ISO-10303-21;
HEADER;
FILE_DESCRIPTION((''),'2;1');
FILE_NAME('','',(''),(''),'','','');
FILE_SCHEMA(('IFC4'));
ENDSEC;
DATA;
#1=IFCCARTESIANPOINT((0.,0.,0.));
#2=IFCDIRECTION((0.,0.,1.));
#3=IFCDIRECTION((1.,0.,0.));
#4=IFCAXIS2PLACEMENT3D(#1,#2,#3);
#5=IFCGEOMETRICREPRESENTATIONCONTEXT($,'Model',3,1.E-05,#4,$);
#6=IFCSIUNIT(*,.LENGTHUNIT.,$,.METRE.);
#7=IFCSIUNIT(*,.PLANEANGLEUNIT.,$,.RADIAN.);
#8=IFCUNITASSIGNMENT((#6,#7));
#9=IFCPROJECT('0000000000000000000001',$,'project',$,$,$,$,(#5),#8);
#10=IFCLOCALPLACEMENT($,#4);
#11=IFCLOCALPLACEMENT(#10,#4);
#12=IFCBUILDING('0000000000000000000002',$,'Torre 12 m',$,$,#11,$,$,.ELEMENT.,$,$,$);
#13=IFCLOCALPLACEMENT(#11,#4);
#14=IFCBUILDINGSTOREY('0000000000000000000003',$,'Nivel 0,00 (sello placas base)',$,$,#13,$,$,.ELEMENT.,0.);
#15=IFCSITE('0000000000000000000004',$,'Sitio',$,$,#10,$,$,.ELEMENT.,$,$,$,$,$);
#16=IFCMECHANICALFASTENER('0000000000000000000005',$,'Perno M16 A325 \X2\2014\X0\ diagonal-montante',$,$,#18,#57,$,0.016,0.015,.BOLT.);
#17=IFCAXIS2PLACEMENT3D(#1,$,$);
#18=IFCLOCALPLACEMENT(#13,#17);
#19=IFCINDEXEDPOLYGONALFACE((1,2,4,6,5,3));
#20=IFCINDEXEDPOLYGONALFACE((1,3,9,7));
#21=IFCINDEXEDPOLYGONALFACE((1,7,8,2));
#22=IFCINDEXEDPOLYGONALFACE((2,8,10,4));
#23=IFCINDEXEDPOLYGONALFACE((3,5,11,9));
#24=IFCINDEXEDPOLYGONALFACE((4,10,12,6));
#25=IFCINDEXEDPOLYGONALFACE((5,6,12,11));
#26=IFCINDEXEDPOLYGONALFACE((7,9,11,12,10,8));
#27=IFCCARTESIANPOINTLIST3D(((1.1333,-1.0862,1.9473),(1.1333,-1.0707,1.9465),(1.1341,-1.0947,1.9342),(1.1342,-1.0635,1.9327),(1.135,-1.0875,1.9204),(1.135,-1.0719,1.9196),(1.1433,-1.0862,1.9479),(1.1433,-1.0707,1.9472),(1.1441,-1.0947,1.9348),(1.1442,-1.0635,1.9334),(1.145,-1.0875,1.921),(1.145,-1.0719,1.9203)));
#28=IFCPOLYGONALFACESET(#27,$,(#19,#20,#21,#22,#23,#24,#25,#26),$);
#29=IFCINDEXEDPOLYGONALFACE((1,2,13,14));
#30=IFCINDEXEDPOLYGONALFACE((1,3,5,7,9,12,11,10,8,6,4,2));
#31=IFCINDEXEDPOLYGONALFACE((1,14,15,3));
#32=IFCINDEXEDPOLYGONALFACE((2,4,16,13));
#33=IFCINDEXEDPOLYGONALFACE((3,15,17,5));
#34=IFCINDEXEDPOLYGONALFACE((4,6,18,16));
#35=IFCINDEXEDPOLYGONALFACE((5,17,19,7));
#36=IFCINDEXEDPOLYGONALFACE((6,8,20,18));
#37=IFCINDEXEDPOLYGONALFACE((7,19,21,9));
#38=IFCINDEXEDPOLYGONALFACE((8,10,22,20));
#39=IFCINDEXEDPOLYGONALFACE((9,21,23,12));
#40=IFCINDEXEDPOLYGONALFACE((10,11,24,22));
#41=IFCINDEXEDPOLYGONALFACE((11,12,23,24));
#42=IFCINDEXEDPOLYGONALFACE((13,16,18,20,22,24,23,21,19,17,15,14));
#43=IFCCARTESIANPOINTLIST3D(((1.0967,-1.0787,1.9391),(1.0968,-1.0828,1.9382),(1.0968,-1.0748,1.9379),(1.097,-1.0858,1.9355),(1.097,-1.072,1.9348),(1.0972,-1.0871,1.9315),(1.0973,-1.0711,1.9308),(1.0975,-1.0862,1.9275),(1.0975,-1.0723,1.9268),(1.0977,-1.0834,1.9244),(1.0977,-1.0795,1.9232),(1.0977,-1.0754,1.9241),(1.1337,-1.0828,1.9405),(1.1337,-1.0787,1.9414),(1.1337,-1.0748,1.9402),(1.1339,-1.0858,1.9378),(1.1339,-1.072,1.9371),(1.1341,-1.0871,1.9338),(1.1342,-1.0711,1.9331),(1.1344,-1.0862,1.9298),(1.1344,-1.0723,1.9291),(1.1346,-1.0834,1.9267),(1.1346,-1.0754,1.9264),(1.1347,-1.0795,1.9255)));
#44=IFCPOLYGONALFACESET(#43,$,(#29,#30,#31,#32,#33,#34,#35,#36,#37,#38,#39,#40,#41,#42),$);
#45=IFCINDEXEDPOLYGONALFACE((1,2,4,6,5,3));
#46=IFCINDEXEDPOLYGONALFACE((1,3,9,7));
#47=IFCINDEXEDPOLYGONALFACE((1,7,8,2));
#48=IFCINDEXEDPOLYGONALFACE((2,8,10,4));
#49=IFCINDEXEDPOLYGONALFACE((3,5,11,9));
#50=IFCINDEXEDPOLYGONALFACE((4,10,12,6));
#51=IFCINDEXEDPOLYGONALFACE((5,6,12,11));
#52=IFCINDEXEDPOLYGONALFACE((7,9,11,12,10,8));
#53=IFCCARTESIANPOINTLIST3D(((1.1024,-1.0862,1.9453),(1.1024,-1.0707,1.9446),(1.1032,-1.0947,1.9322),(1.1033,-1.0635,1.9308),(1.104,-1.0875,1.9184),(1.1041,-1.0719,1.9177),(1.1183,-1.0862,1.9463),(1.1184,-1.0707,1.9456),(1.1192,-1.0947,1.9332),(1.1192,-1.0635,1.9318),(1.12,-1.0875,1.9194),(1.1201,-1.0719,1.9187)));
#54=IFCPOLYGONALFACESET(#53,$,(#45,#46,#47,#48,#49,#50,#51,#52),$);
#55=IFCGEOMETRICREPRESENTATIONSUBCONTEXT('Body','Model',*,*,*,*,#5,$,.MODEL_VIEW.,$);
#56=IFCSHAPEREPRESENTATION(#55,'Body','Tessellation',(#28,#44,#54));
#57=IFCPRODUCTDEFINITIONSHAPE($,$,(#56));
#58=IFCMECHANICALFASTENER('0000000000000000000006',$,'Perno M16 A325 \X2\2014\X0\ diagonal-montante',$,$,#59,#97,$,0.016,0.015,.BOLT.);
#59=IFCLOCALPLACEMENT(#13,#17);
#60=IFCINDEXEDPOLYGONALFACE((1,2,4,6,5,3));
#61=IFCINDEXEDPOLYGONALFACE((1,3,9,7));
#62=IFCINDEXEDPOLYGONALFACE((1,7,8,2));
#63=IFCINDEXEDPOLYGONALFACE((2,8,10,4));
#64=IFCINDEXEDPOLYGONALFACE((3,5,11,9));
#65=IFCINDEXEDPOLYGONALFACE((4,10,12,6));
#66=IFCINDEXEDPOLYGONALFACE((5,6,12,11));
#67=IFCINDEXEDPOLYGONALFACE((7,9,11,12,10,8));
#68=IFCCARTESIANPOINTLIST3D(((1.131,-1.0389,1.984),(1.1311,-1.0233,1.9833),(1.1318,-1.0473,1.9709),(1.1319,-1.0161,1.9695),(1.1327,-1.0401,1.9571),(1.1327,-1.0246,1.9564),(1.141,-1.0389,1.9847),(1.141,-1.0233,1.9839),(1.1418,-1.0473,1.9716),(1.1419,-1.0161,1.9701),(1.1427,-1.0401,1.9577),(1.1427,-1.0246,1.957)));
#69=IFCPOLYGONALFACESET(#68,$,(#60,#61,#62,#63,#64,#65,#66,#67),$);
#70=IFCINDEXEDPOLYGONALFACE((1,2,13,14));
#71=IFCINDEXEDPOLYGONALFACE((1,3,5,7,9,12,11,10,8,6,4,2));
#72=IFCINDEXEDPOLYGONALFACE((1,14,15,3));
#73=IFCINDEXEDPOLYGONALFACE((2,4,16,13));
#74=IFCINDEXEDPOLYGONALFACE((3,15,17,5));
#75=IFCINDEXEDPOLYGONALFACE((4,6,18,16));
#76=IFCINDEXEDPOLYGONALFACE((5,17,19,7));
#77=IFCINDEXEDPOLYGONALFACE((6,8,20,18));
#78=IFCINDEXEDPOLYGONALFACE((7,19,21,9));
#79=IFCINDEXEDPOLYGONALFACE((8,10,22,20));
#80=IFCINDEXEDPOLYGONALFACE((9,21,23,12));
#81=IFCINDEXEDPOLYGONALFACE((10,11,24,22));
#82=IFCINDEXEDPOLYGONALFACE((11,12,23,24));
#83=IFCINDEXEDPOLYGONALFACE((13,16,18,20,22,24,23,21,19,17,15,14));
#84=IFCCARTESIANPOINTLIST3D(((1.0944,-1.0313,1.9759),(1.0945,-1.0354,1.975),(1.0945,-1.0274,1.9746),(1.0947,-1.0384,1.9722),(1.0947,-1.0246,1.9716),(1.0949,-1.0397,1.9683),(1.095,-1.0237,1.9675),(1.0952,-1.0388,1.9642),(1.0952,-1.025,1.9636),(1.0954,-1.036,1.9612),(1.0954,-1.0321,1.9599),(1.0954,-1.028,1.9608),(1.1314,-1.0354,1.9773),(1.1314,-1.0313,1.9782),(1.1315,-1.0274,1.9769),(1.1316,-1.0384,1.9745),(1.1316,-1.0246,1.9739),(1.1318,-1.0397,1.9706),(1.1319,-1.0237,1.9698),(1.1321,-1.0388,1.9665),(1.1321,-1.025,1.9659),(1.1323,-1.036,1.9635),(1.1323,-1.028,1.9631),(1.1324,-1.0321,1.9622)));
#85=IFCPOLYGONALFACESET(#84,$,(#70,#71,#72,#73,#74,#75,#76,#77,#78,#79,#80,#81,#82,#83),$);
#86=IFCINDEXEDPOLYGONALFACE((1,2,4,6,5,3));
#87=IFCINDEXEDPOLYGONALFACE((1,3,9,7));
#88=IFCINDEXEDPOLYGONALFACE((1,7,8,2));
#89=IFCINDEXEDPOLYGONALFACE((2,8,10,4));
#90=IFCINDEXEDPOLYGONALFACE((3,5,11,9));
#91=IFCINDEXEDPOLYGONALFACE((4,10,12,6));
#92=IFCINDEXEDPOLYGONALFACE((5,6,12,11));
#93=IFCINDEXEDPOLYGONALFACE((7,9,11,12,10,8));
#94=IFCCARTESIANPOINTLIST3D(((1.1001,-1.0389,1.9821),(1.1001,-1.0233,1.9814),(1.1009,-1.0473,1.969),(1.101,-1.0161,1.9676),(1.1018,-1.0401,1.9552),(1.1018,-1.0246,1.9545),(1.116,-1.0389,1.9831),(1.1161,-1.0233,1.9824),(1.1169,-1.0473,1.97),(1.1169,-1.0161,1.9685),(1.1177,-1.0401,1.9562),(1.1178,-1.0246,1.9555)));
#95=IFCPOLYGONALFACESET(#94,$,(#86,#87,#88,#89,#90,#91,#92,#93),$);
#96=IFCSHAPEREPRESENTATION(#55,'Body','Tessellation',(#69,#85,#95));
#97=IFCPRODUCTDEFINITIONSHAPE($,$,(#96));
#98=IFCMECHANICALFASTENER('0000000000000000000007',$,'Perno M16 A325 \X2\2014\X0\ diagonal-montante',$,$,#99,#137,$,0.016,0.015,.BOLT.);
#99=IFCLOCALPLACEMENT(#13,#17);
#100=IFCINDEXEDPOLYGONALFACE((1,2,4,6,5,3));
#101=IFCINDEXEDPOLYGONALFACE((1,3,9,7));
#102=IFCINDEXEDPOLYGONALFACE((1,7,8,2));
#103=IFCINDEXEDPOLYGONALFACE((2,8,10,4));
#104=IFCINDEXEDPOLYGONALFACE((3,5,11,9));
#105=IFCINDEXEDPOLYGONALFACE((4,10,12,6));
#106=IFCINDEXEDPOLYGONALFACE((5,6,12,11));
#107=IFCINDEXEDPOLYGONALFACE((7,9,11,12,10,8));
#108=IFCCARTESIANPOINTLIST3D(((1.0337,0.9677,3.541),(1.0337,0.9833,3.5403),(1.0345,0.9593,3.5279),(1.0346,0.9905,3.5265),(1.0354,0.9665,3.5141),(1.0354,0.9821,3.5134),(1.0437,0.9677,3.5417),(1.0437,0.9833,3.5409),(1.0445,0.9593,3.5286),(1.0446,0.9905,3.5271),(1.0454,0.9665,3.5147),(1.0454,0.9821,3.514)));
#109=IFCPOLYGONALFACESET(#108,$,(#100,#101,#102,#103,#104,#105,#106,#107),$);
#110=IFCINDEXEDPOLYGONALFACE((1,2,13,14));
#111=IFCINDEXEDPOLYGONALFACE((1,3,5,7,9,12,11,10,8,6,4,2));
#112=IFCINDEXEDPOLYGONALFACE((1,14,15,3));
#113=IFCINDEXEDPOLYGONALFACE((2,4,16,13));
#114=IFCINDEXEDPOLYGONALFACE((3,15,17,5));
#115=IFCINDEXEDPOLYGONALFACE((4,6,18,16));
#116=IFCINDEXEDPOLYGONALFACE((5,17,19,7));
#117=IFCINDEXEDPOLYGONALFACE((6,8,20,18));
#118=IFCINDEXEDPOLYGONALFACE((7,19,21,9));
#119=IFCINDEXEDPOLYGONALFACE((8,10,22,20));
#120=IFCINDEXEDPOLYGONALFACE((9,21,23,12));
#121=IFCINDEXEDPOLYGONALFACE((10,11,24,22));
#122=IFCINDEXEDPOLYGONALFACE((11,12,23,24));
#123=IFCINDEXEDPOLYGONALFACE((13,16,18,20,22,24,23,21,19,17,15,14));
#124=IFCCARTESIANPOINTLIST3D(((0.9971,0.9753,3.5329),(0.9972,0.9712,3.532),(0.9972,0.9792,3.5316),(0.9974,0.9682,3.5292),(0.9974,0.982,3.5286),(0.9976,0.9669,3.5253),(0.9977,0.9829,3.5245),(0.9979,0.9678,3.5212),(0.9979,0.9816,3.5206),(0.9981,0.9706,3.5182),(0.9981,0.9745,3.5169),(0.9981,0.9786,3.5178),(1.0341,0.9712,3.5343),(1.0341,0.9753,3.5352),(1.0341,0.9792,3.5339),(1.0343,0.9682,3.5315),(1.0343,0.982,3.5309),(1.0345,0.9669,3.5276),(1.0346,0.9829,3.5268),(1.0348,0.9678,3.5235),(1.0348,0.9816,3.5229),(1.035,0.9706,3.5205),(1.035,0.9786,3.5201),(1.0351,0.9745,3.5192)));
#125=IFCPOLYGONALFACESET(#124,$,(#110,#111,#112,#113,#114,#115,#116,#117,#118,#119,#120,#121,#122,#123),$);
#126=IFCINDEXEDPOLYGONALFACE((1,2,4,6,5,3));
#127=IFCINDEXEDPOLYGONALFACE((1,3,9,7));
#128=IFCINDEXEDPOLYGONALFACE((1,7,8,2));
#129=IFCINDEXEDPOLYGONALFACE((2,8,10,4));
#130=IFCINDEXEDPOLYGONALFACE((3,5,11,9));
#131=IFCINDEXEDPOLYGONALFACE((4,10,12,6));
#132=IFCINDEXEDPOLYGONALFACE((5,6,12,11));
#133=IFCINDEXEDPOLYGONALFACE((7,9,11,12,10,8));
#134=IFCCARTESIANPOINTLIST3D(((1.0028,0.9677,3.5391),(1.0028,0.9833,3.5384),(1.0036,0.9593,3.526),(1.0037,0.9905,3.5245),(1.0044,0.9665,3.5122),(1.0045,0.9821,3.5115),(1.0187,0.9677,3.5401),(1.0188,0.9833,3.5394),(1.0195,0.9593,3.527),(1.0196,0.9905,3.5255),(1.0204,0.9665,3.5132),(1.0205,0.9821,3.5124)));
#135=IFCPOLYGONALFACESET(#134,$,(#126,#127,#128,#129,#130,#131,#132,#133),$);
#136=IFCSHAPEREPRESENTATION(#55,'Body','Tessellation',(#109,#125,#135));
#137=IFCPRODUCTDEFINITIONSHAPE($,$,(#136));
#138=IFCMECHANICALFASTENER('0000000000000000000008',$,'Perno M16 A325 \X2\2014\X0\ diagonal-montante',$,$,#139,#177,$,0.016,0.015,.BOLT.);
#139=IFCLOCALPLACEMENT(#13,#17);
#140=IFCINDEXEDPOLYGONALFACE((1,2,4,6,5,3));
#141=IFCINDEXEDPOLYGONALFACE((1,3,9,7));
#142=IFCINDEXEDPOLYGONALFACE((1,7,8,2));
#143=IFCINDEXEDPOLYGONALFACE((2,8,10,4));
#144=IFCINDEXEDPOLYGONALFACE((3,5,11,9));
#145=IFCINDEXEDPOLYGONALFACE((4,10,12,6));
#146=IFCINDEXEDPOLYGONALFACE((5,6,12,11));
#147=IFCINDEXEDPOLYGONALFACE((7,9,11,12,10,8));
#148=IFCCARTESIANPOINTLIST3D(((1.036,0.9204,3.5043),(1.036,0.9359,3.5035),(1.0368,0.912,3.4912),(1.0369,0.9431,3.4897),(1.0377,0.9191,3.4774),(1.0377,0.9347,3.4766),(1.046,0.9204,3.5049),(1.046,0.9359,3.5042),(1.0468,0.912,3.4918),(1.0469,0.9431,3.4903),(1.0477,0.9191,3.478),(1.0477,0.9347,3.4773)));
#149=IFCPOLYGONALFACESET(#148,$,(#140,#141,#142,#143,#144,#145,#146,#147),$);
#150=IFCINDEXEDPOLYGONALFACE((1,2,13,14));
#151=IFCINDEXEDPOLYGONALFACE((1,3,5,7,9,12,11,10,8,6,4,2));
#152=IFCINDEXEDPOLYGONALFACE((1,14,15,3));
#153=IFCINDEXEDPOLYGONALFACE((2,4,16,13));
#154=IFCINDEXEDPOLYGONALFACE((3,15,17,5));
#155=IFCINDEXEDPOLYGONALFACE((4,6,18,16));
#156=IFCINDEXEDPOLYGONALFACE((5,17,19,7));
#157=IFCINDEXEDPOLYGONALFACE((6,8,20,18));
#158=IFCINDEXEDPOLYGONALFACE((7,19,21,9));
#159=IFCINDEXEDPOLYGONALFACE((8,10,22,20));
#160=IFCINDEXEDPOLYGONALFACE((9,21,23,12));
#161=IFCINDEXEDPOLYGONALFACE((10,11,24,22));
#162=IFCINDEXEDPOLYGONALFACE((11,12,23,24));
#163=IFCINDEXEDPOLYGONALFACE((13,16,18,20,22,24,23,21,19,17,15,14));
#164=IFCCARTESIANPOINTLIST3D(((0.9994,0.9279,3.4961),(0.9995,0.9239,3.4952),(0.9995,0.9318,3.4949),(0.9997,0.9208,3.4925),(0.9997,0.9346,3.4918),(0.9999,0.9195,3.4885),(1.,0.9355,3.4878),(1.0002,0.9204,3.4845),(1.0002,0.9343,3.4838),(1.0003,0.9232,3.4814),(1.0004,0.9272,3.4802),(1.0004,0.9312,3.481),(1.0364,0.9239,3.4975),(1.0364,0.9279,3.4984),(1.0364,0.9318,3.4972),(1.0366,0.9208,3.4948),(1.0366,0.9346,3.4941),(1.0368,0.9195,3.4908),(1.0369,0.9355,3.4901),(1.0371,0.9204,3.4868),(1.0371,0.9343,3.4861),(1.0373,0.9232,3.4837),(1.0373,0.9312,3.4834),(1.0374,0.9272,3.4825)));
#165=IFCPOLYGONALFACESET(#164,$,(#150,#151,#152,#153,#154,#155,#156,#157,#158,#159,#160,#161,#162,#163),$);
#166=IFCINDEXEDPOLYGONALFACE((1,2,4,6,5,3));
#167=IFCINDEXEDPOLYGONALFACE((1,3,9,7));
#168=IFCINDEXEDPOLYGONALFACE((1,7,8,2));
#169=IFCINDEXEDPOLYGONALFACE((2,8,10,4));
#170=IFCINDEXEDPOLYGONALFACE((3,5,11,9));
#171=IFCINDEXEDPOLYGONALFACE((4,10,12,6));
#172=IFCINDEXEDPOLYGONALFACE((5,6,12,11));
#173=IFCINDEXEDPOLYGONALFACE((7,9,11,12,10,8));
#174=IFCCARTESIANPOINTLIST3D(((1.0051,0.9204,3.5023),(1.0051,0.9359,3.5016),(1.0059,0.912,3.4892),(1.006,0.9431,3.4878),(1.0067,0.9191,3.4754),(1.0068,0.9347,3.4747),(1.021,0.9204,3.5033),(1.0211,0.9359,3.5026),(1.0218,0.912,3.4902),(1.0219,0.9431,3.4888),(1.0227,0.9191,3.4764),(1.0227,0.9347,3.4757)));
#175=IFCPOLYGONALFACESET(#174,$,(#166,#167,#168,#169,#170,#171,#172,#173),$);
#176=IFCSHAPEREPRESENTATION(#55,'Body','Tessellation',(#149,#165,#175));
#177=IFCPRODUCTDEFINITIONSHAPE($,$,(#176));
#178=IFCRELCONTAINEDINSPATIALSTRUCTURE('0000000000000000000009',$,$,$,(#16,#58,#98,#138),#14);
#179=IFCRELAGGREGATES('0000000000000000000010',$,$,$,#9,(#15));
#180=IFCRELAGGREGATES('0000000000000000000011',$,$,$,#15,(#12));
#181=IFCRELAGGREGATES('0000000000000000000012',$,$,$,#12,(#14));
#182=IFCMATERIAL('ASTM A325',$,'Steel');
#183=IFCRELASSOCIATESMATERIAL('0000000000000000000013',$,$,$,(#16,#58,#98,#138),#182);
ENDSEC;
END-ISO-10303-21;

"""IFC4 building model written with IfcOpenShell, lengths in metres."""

from ifc_helpers import new_model, si_unit, frame, origin_with_axes, place, context, subcontext, project, spatial, polyline, outline, extrude, material, element, save


model = new_model("IFC4")

# Units and contexts
model_context = context("Model", 3, precision=1e-05, world=origin_with_axes())
body_context = subcontext(model_context, "Body", "Model", "MODEL_VIEW")
ifc_project = project(units=[si_unit("LENGTHUNIT", "METRE"), si_unit("PLANEANGLEUNIT", "RADIAN")], contexts=[model_context])

# Site, building, storey
site_placement = place(None, origin_with_axes())
site = spatial("IfcSite", under=ifc_project, at=site_placement, Name="Sitio", CompositionType="ELEMENT")
building_placement = place(site_placement, origin_with_axes())
building = spatial("IfcBuilding", under=site, at=building_placement, Name="Torre 12 m", CompositionType="ELEMENT")
storey_placement = place(building_placement, origin_with_axes())
storey = spatial("IfcBuildingStorey", under=building, at=storey_placement, Name="Nivel 0,00 (sello placas base)", CompositionType="ELEMENT", Elevation=0.0)

# Shared definitions
placement = place(storey_placement, origin_with_axes())

# Mechanical fasteners
ifc_material_1 = material(Name="ASTM A325", Category="Steel")
element("IfcMechanicalFastener", 1, at=placement, inside=storey, material=ifc_material_1, Name="Perno M16 A325 — diagonal-montante", NominalDiameter=0.016, NominalLength=0.015, PredefinedType="BOLT", context=body_context, shape_type="SweptSolid", body=[
    extrude(outline(polyline([(0.0135, 0.0078), (0.0, 0.0156), (-0.0135, 0.0078), (-0.0135, -0.0078), (0.0, -0.0156), (0.0135, -0.0078), (0.0135, 0.0078)])), frame((1.1441, -1.0791, 1.9341), z_axis=(-0.998053, 0.0, -0.062378), x_axis=(0.033672, 0.841794, -0.538748)), (0.0, 0.0, 1.0), 0.01),
    extrude(outline(polyline([(0.008, 0.0), (0.0069, 0.004), (0.004, 0.0069), (0.0, 0.008), (-0.004, 0.0069), (-0.0069, 0.004), (-0.008, 0.0), (-0.0069, -0.004), (-0.004, -0.0069), (0.0, -0.008), (0.004, -0.0069), (0.0069, -0.004), (0.008, 0.0)])), frame((1.1342, -1.0791, 1.9335), z_axis=(-0.998053, 0.0, -0.062378), x_axis=(0.033672, 0.841794, -0.538748)), (0.0, 0.0, 1.0), 0.037),
    extrude(outline(polyline([(0.0135, 0.0078), (0.0, 0.0156), (-0.0135, 0.0078), (-0.0135, -0.0078), (0.0, -0.0156), (0.0135, -0.0078), (0.0135, 0.0078)])), frame((1.1192, -1.0791, 1.9325), z_axis=(-0.998053, 0.0, -0.062378), x_axis=(0.033672, 0.841794, -0.538748)), (0.0, 0.0, 1.0), 0.016),
])
element("IfcMechanicalFastener", 2, at=placement, inside=storey, material=ifc_material_1, Name="Perno M16 A325 — diagonal-montante", NominalDiameter=0.016, NominalLength=0.015, PredefinedType="BOLT", context=body_context, shape_type="SweptSolid", body=[
    extrude(outline(polyline([(0.0135, 0.0078), (0.0, 0.0156), (-0.0135, 0.0078), (-0.0135, -0.0078), (0.0, -0.0156), (0.0135, -0.0078), (0.0135, 0.0078)])), frame((1.1419, -1.0317, 1.9708), z_axis=(-0.998053, 0.0, -0.062378), x_axis=(0.033672, 0.841794, -0.538748)), (0.0, 0.0, 1.0), 0.01),
    extrude(outline(polyline([(0.008, 0.0), (0.0069, 0.004), (0.004, 0.0069), (0.0, 0.008), (-0.004, 0.0069), (-0.0069, 0.004), (-0.008, 0.0), (-0.0069, -0.004), (-0.004, -0.0069), (0.0, -0.008), (0.004, -0.0069), (0.0069, -0.004), (0.008, 0.0)])), frame((1.1319, -1.0317, 1.9702), z_axis=(-0.998053, 0.0, -0.062378), x_axis=(0.033672, 0.841794, -0.538748)), (0.0, 0.0, 1.0), 0.037),
    extrude(outline(polyline([(0.0135, 0.0078), (0.0, 0.0156), (-0.0135, 0.0078), (-0.0135, -0.0078), (0.0, -0.0156), (0.0135, -0.0078), (0.0135, 0.0078)])), frame((1.1169, -1.0317, 1.9693), z_axis=(-0.998053, 0.0, -0.062378), x_axis=(0.033672, 0.841794, -0.538748)), (0.0, 0.0, 1.0), 0.016),
])
element("IfcMechanicalFastener", 3, at=placement, inside=storey, material=ifc_material_1, Name="Perno M16 A325 — diagonal-montante", NominalDiameter=0.016, NominalLength=0.015, PredefinedType="BOLT", context=body_context, shape_type="SweptSolid", body=[
    extrude(outline(polyline([(0.0135, 0.0078), (0.0, 0.0156), (-0.0135, 0.0078), (-0.0135, -0.0078), (0.0, -0.0156), (0.0135, -0.0078), (0.0135, 0.0078)])), frame((1.0445, 0.9749, 3.5278), z_axis=(-0.998053, 0.0, -0.062378), x_axis=(0.033672, 0.841794, -0.538748)), (0.0, 0.0, 1.0), 0.01),
    extrude(outline(polyline([(0.008, 0.0), (0.0069, 0.004), (0.004, 0.0069), (0.0, 0.008), (-0.004, 0.0069), (-0.0069, 0.004), (-0.008, 0.0), (-0.0069, -0.004), (-0.004, -0.0069), (0.0, -0.008), (0.004, -0.0069), (0.0069, -0.004), (0.008, 0.0)])), frame((1.0346, 0.9749, 3.5272), z_axis=(-0.998053, 0.0, -0.062378), x_axis=(0.033672, 0.841794, -0.538748)), (0.0, 0.0, 1.0), 0.037),
    extrude(outline(polyline([(0.0135, 0.0078), (0.0, 0.0156), (-0.0135, 0.0078), (-0.0135, -0.0078), (0.0, -0.0156), (0.0135, -0.0078), (0.0135, 0.0078)])), frame((1.0196, 0.9749, 3.5263), z_axis=(-0.998053, 0.0, -0.062378), x_axis=(0.033672, 0.841794, -0.538748)), (0.0, 0.0, 1.0), 0.016),
])
element("IfcMechanicalFastener", 4, at=placement, inside=storey, material=ifc_material_1, Name="Perno M16 A325 — diagonal-montante", NominalDiameter=0.016, NominalLength=0.015, PredefinedType="BOLT", context=body_context, shape_type="SweptSolid", body=[
    extrude(outline(polyline([(0.0135, 0.0078), (0.0, 0.0156), (-0.0135, 0.0078), (-0.0135, -0.0078), (0.0, -0.0156), (0.0135, -0.0078), (0.0135, 0.0078)])), frame((1.0468, 0.9275, 3.4911), z_axis=(-0.998053, 0.0, -0.062378), x_axis=(0.033672, 0.841794, -0.538748)), (0.0, 0.0, 1.0), 0.01),
    extrude(outline(polyline([(0.008, 0.0), (0.0069, 0.004), (0.004, 0.0069), (0.0, 0.008), (-0.004, 0.0069), (-0.0069, 0.004), (-0.008, 0.0), (-0.0069, -0.004), (-0.004, -0.0069), (0.0, -0.008), (0.004, -0.0069), (0.0069, -0.004), (0.008, 0.0)])), frame((1.0369, 0.9275, 3.4905), z_axis=(-0.998053, 0.0, -0.062378), x_axis=(0.033672, 0.841794, -0.538748)), (0.0, 0.0, 1.0), 0.037),
    extrude(outline(polyline([(0.0135, 0.0078), (0.0, 0.0156), (-0.0135, 0.0078), (-0.0135, -0.0078), (0.0, -0.0156), (0.0135, -0.0078), (0.0135, 0.0078)])), frame((1.0219, 0.9275, 3.4895), z_axis=(-0.998053, 0.0, -0.062378), x_axis=(0.033672, 0.841794, -0.538748)), (0.0, 0.0, 1.0), 0.016),
])

save(model, "model.ifc")
